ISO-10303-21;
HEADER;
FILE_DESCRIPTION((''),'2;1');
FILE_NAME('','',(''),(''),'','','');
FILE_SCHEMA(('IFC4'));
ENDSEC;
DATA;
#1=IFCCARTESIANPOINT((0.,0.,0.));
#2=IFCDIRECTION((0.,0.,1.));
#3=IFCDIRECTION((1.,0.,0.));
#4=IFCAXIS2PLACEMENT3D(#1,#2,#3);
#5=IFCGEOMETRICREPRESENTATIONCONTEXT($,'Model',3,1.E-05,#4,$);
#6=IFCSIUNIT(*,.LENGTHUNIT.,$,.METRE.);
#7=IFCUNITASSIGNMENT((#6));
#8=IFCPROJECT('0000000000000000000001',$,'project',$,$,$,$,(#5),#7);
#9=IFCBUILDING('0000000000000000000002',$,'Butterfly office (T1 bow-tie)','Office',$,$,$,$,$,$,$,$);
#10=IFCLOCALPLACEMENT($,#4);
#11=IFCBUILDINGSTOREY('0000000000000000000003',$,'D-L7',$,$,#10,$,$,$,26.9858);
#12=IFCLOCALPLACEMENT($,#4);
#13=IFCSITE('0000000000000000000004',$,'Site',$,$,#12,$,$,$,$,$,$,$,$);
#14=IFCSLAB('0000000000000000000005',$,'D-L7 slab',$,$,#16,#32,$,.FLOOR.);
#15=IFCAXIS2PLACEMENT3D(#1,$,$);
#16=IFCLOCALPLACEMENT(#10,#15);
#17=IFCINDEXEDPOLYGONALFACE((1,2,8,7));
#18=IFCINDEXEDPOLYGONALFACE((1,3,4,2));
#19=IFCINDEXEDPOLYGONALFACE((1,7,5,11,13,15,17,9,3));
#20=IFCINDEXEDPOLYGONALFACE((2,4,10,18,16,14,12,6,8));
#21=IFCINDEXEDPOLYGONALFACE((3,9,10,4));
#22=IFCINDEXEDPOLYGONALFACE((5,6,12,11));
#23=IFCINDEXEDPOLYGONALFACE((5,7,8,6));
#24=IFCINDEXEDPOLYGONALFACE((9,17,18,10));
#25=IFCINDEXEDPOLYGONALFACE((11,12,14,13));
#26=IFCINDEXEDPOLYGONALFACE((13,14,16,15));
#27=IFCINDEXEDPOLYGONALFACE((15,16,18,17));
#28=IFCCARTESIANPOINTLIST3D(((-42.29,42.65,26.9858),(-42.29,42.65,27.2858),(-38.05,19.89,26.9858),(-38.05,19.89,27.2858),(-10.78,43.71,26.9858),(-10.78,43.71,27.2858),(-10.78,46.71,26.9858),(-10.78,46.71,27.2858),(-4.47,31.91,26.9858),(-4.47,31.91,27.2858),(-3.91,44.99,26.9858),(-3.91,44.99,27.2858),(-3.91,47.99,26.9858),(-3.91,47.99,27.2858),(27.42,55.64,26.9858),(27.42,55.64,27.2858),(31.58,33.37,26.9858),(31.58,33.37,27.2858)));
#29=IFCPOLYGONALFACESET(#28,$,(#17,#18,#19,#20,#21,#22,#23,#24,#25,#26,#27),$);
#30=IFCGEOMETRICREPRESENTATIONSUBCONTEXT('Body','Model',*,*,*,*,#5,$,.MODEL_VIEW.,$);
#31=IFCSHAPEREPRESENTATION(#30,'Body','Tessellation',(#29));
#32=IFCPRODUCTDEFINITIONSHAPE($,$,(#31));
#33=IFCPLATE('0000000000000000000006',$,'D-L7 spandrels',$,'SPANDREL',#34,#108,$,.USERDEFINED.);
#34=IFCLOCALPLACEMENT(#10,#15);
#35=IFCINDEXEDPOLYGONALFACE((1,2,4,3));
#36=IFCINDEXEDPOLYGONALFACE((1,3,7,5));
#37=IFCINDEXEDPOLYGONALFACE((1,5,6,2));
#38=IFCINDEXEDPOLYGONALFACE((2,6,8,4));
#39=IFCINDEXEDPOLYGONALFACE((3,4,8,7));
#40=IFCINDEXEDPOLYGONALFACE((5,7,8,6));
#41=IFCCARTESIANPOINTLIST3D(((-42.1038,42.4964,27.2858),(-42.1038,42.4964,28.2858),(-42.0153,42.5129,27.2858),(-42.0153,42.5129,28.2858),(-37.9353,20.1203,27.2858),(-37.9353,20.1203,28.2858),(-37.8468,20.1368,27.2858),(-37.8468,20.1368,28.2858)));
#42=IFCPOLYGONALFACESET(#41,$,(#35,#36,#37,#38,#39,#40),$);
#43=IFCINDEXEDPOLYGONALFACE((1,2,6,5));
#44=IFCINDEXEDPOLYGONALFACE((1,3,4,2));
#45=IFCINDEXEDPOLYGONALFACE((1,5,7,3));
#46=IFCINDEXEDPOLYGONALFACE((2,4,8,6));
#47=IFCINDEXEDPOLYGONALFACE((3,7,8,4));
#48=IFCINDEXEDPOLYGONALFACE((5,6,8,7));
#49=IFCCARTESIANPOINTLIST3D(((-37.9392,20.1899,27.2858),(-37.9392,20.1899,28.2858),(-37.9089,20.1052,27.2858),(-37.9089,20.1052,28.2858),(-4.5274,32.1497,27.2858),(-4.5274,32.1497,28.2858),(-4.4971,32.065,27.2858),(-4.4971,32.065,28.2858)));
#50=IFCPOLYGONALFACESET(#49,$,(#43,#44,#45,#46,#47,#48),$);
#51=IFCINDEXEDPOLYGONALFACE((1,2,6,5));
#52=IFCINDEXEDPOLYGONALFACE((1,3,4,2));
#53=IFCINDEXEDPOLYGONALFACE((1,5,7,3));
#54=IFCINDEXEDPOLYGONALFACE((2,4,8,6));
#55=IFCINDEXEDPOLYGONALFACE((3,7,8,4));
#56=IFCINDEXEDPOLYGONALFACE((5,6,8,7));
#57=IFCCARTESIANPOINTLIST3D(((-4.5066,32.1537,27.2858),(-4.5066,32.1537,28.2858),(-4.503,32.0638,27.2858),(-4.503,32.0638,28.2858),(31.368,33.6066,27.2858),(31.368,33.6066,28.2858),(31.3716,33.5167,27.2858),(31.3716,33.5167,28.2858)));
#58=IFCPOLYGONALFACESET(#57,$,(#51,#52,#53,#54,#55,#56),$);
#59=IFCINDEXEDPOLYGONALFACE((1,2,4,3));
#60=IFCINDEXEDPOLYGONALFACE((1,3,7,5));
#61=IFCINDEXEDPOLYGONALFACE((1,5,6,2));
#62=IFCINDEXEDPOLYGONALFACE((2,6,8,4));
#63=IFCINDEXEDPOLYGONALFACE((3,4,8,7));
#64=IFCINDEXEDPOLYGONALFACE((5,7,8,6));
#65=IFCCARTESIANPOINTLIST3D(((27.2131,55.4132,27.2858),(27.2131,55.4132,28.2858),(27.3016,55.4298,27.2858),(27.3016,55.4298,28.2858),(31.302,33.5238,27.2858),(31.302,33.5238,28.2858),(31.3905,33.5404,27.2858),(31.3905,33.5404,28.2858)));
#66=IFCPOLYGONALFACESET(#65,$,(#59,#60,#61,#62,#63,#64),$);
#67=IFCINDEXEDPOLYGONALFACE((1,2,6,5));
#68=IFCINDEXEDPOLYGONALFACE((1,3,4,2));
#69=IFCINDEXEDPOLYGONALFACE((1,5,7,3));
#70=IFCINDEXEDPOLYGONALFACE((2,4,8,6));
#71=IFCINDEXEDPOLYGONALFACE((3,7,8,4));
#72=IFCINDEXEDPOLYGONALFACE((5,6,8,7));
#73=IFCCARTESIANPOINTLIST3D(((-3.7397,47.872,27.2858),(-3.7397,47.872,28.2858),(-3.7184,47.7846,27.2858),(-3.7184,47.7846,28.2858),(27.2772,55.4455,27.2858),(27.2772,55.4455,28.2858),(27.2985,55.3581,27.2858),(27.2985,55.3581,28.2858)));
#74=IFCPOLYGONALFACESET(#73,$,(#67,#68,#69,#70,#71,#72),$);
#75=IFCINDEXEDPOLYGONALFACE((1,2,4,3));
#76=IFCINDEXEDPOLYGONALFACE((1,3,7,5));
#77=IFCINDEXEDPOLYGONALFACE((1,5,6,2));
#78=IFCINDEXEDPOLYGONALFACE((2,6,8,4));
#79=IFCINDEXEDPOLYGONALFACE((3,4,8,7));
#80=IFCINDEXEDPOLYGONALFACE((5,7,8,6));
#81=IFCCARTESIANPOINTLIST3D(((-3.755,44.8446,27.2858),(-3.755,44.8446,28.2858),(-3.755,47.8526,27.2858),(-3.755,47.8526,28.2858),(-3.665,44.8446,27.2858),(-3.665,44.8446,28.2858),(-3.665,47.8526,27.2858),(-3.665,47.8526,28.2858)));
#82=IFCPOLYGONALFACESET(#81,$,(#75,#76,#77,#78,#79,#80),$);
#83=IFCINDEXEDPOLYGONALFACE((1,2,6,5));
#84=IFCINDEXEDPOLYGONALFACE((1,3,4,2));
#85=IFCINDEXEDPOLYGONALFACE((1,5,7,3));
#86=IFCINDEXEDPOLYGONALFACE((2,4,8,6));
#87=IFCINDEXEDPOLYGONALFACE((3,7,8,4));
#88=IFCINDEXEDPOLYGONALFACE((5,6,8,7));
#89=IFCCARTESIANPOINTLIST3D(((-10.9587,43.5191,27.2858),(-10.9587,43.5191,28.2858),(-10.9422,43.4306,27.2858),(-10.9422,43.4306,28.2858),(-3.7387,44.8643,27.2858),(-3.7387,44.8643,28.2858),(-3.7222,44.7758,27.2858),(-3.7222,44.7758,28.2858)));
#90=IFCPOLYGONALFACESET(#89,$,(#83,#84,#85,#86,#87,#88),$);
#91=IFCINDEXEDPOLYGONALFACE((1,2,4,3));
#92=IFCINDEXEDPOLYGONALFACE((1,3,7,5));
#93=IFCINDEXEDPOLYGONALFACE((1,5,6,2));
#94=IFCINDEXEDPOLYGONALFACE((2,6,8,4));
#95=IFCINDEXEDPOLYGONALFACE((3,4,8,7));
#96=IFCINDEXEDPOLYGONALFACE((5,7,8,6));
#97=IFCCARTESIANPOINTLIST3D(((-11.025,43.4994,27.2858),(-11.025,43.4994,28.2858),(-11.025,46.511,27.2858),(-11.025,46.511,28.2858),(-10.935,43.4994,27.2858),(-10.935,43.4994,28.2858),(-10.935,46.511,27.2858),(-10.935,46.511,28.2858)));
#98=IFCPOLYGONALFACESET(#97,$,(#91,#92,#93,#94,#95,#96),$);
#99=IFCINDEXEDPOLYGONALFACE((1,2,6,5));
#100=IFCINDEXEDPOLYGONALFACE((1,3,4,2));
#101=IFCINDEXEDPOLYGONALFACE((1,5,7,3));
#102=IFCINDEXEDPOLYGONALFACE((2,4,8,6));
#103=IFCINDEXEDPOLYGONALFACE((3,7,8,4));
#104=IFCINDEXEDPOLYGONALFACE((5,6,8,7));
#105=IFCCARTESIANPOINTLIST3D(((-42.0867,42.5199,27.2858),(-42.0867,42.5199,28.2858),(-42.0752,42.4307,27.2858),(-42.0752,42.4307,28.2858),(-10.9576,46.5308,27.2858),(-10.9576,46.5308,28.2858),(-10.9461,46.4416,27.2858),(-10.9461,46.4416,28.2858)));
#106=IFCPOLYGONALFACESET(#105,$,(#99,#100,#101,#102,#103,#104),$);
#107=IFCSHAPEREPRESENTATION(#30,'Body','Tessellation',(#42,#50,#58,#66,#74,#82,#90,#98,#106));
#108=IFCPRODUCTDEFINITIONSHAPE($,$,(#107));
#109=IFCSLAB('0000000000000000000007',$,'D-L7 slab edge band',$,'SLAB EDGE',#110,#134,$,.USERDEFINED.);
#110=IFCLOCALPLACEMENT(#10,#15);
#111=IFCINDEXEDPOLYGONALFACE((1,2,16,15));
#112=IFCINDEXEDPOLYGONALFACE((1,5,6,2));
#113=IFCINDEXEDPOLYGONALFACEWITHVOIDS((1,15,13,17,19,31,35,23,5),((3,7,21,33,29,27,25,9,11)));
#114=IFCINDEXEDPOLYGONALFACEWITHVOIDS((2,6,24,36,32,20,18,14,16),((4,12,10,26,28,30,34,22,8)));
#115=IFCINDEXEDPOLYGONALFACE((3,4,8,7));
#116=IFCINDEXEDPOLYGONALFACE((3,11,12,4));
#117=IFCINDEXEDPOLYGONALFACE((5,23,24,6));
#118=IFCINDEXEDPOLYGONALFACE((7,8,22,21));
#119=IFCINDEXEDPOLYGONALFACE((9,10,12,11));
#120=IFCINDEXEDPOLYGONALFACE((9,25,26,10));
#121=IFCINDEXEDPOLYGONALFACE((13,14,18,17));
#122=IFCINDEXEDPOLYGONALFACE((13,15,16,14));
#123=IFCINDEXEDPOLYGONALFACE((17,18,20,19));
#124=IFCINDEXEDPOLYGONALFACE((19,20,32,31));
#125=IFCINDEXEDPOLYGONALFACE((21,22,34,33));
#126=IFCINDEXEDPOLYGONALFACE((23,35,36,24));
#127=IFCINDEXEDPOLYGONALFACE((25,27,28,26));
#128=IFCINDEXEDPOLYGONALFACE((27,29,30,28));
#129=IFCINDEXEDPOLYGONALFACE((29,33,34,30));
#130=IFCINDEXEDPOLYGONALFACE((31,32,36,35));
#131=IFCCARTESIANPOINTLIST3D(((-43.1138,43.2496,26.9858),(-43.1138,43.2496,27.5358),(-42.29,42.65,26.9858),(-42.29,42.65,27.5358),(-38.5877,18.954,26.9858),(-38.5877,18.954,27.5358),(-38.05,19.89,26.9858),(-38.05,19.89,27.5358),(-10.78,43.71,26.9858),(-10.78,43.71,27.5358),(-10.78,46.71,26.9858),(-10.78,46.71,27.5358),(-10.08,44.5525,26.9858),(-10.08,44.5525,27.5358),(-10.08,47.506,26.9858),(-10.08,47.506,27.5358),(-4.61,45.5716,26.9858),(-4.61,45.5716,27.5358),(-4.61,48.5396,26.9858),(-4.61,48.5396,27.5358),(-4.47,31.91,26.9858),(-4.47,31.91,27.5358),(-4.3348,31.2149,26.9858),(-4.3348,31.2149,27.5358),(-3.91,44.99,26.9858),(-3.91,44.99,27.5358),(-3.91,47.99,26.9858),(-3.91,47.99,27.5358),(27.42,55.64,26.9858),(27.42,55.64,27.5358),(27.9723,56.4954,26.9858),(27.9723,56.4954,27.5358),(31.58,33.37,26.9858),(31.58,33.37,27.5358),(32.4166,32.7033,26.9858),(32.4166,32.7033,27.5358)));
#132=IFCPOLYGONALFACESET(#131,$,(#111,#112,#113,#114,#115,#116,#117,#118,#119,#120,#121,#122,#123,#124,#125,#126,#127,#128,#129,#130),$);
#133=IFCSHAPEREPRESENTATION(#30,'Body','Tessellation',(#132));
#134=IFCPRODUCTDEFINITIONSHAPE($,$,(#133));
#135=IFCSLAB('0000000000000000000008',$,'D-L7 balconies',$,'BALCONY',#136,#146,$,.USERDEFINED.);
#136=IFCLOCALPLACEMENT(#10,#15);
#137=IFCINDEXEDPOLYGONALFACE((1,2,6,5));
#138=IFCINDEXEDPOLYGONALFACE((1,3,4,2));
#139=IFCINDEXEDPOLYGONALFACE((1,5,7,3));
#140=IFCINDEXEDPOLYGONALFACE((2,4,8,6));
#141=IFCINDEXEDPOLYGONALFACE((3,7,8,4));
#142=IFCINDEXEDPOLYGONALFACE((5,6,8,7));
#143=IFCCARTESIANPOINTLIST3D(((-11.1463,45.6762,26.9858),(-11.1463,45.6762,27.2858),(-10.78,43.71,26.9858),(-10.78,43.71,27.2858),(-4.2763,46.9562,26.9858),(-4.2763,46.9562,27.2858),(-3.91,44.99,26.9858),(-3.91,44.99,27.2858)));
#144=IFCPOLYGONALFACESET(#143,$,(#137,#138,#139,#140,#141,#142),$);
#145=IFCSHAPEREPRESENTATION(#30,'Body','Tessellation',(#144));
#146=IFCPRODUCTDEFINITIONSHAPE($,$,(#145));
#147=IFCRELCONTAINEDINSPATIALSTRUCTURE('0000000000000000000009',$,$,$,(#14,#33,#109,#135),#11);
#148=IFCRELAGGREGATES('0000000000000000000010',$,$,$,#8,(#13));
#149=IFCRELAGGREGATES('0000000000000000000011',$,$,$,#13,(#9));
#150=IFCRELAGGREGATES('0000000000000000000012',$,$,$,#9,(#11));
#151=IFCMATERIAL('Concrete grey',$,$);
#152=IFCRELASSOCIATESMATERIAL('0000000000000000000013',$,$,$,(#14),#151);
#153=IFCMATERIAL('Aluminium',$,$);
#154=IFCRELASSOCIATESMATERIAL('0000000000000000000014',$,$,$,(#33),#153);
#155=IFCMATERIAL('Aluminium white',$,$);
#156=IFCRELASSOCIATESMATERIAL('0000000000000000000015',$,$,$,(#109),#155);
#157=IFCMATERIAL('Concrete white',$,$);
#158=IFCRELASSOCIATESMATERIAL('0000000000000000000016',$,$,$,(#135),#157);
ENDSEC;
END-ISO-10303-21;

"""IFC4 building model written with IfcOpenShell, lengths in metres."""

from ifc_helpers import new_model, si_unit, frame, origin_with_axes, place, context, subcontext, project, spatial, polyline, outline, extrude, material, element, save


model = new_model("IFC4")

# Units and contexts
model_context = context("Model", 3, precision=1e-05, world=origin_with_axes())
body_context = subcontext(model_context, "Body", "Model", "MODEL_VIEW")
ifc_project = project(units=[si_unit("LENGTHUNIT", "METRE")], contexts=[model_context])

# Site, building, storey
site_placement = place(None, origin_with_axes())
site = spatial("IfcSite", under=ifc_project, at=site_placement, Name="Site")
building = spatial("IfcBuilding", under=site, Name="Butterfly office (T1 bow-tie)", Description="Office")
storey_placement = place(None, origin_with_axes())
storey = spatial("IfcBuildingStorey", under=building, at=storey_placement, Name="D-L7", Elevation=26.9858)

# Shared definitions
ifc_material_1 = material(Name="Aluminium")

# Slab
ifc_material_2 = material(Name="Concrete grey")
slab_1_placement = place(storey_placement, origin_with_axes())
element("IfcSlab", 1, at=slab_1_placement, inside=storey, material=ifc_material_2, Name="D-L7 slab", PredefinedType="FLOOR", context=body_context, shape_type="SweptSolid", body=[
    extrude(outline(polyline([(-42.29, 42.65), (-38.05, 19.89), (-4.47, 31.91), (31.58, 33.37), (27.42, 55.64), (-3.91, 47.99), (-3.91, 44.99), (-10.78, 43.71), (-10.78, 46.71), (-42.29, 42.65)])), frame((0.0, 0.0, 26.9858), z_axis=(0.0, 0.0, 1.0), x_axis=(1.0, 0.0, 0.0)), (0.0, 0.0, 1.0), 0.3),
])

# Plate
plate_placement = place(storey_placement, origin_with_axes())
element("IfcPlate", 2, at=plate_placement, inside=storey, material=ifc_material_1, Name="D-L7 spandrels", ObjectType="SPANDREL", PredefinedType="USERDEFINED", context=body_context, shape_type="SweptSolid", body=[
    extrude(outline(polyline([(-42.1038, 42.4964), (-37.9353, 20.1203), (-37.8468, 20.1368), (-42.0153, 42.5129), (-42.1038, 42.4964)])), frame((0.0, 0.0, 27.2858), z_axis=(0.0, 0.0, 1.0), x_axis=(1.0, 0.0, 0.0)), (0.0, 0.0, 1.0), 1.0),
    extrude(outline(polyline([(-37.9089, 20.1052), (-4.4971, 32.065), (-4.5274, 32.1497), (-37.9392, 20.1899), (-37.9089, 20.1052)])), frame((0.0, 0.0, 27.2858), z_axis=(0.0, 0.0, 1.0), x_axis=(1.0, 0.0, 0.0)), (0.0, 0.0, 1.0), 1.0),
    extrude(outline(polyline([(-4.503, 32.0638), (31.3716, 33.5167), (31.368, 33.6066), (-4.5066, 32.1537), (-4.503, 32.0638)])), frame((0.0, 0.0, 27.2858), z_axis=(0.0, 0.0, 1.0), x_axis=(1.0, 0.0, 0.0)), (0.0, 0.0, 1.0), 1.0),
    extrude(outline(polyline([(31.3905, 33.5404), (27.3016, 55.4298), (27.2131, 55.4132), (31.302, 33.5238), (31.3905, 33.5404)])), frame((0.0, 0.0, 27.2858), z_axis=(0.0, 0.0, 1.0), x_axis=(1.0, 0.0, 0.0)), (0.0, 0.0, 1.0), 1.0),
    extrude(outline(polyline([(27.2772, 55.4455), (-3.7397, 47.872), (-3.7184, 47.7846), (27.2985, 55.3581), (27.2772, 55.4455)])), frame((0.0, 0.0, 27.2858), z_axis=(0.0, 0.0, 1.0), x_axis=(1.0, 0.0, 0.0)), (0.0, 0.0, 1.0), 1.0),
    extrude(outline(polyline([(-3.755, 47.8526), (-3.755, 44.8446), (-3.665, 44.8446), (-3.665, 47.8526), (-3.755, 47.8526)])), frame((0.0, 0.0, 27.2858), z_axis=(0.0, 0.0, 1.0), x_axis=(1.0, 0.0, 0.0)), (0.0, 0.0, 1.0), 1.0),
    extrude(outline(polyline([(-3.7387, 44.8643), (-10.9587, 43.5191), (-10.9422, 43.4306), (-3.7222, 44.7758), (-3.7387, 44.8643)])), frame((0.0, 0.0, 27.2858), z_axis=(0.0, 0.0, 1.0), x_axis=(1.0, 0.0, 0.0)), (0.0, 0.0, 1.0), 1.0),
    extrude(outline(polyline([(-10.935, 43.4994), (-10.935, 46.511), (-11.025, 46.511), (-11.025, 43.4994), (-10.935, 43.4994)])), frame((0.0, 0.0, 27.2858), z_axis=(0.0, 0.0, 1.0), x_axis=(1.0, 0.0, 0.0)), (0.0, 0.0, 1.0), 1.0),
    extrude(outline(polyline([(-10.9576, 46.5308), (-42.0867, 42.5199), (-42.0752, 42.4307), (-10.9461, 46.4416), (-10.9576, 46.5308)])), frame((0.0, 0.0, 27.2858), z_axis=(0.0, 0.0, 1.0), x_axis=(1.0, 0.0, 0.0)), (0.0, 0.0, 1.0), 1.0),
])

# Slabs
ifc_material_3 = material(Name="Aluminium white")
slab_2_placement = place(storey_placement, origin_with_axes())
element("IfcSlab", 3, at=slab_2_placement, inside=storey, material=ifc_material_3, Name="D-L7 slab edge band", ObjectType="SLAB EDGE", PredefinedType="USERDEFINED", context=body_context, shape_type="SweptSolid", body=[
    extrude(outline(polyline([(-43.1138, 43.2496), (-38.5877, 18.954), (-4.3348, 31.2149), (32.4166, 32.7033), (27.9723, 56.4954), (-4.61, 48.5396), (-4.61, 45.5716), (-10.08, 44.5525), (-10.08, 47.506), (-43.1138, 43.2496)]), holes=[polyline([(-42.29, 42.65), (-38.05, 19.89), (-4.47, 31.91), (31.58, 33.37), (27.42, 55.64), (-3.91, 47.99), (-3.91, 44.99), (-10.78, 43.71), (-10.78, 46.71), (-42.29, 42.65)])]), frame((0.0, 0.0, 26.9858), z_axis=(0.0, 0.0, 1.0), x_axis=(1.0, 0.0, 0.0)), (0.0, 0.0, 1.0), 0.55),
])
ifc_material_4 = material(Name="Concrete white")
slab_3_placement = place(storey_placement, origin_with_axes())
element("IfcSlab", 4, at=slab_3_placement, inside=storey, material=ifc_material_4, Name="D-L7 balconies", ObjectType="BALCONY", PredefinedType="USERDEFINED", context=body_context, shape_type="SweptSolid", body=[
    extrude(outline(polyline([(-3.91, 44.99), (-10.78, 43.71), (-11.1463, 45.6762), (-4.2763, 46.9562), (-3.91, 44.99)])), frame((0.0, 0.0, 26.9858), z_axis=(0.0, 0.0, 1.0), x_axis=(1.0, 0.0, 0.0)), (0.0, 0.0, 1.0), 0.3),
])

save(model, "model.ifc")
